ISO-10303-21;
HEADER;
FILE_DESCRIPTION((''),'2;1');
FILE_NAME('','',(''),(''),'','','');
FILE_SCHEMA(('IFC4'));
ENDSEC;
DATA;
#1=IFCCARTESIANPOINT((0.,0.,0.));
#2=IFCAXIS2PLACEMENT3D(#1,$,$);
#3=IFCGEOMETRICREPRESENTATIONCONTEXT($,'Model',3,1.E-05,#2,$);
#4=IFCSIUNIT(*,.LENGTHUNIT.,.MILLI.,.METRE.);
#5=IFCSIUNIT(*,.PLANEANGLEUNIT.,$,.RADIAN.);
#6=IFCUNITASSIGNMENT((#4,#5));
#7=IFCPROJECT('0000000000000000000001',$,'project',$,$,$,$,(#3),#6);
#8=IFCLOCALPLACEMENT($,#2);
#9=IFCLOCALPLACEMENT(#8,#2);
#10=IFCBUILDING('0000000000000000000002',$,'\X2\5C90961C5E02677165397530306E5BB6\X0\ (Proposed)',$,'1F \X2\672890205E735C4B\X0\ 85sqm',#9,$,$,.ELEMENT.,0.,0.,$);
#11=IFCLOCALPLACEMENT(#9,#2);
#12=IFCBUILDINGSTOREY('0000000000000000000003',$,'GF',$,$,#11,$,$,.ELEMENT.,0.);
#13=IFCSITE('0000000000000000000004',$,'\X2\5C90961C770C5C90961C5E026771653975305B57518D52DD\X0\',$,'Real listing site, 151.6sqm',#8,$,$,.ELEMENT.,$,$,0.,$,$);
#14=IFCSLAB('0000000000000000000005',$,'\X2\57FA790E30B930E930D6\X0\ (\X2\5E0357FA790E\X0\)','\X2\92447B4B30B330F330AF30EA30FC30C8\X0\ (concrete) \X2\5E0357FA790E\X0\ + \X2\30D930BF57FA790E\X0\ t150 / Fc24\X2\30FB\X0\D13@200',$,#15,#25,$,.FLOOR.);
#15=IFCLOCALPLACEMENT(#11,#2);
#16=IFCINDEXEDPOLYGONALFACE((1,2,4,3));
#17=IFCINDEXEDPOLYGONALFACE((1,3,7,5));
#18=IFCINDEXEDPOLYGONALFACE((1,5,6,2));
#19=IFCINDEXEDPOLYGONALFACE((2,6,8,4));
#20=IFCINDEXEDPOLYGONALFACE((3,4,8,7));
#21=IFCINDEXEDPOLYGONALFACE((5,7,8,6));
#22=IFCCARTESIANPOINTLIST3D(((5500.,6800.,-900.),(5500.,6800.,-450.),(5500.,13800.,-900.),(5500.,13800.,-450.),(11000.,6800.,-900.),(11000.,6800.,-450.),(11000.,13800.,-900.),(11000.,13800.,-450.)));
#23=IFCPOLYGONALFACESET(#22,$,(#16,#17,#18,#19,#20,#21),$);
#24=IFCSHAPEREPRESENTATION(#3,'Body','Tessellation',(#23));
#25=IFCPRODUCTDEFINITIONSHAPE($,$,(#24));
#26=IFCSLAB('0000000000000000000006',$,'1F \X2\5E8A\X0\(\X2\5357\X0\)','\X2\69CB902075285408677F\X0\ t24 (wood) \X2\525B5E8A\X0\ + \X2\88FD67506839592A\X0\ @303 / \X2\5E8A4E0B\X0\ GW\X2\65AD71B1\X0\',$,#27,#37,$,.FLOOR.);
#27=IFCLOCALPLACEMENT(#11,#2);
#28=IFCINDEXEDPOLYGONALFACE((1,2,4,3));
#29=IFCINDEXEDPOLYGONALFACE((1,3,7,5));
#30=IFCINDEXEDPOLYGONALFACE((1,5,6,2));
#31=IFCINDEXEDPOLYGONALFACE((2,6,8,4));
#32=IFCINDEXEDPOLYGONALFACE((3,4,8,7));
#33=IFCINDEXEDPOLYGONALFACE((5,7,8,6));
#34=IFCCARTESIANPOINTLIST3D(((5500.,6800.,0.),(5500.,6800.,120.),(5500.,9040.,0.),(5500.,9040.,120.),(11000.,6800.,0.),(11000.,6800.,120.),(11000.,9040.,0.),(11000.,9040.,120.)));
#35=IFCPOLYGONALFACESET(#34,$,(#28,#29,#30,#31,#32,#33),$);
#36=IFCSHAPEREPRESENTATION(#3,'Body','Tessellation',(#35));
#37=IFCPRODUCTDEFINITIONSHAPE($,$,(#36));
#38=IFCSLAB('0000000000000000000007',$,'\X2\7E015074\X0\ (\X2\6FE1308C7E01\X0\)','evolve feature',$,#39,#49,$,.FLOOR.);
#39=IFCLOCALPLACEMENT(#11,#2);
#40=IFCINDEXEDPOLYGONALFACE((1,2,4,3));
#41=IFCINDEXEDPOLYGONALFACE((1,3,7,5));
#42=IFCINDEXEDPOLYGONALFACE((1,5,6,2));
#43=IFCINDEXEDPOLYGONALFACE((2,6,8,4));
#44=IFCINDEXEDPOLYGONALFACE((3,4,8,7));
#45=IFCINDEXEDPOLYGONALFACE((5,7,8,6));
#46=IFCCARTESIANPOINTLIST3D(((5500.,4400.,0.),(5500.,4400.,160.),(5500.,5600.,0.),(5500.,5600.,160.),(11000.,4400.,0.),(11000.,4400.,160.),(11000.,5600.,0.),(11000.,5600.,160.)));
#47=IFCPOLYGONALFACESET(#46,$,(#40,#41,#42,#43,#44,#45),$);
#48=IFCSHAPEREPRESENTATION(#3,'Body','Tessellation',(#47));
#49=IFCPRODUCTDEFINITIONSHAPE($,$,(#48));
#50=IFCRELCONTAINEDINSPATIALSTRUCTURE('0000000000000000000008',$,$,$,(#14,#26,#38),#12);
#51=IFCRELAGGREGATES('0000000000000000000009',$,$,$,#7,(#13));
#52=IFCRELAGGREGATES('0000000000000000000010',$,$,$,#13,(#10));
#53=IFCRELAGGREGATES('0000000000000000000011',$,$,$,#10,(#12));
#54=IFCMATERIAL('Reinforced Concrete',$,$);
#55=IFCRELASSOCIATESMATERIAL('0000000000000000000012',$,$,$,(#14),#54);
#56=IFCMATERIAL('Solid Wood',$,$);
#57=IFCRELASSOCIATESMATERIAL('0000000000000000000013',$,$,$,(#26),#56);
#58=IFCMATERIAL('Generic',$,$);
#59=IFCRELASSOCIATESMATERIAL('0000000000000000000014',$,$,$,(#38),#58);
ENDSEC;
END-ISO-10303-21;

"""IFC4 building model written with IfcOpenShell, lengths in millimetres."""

from ifc_helpers import new_model, si_unit, frame, frame_2d, origin, place, context, project, spatial, rectangle, extrude, material, element, save


model = new_model("IFC4")

# Units and contexts
model_context = context("Model", 3, precision=1e-05, world=origin())
ifc_project = project(units=[si_unit("LENGTHUNIT", "METRE", prefix="MILLI"), si_unit("PLANEANGLEUNIT", "RADIAN")], contexts=[model_context])

# Site, building, storey
site_placement = place(None, origin())
site = spatial("IfcSite", under=ifc_project, at=site_placement, Name="岐阜県岐阜市東改田字再勝", ObjectType="Real listing site, 151.6sqm", CompositionType="ELEMENT", RefElevation=0.0)
building_placement = place(site_placement, origin())
building = spatial("IfcBuilding", under=site, at=building_placement, Name="岐阜市東改田の家 (Proposed)", ObjectType="1F 木造平屋 85sqm", CompositionType="ELEMENT", ElevationOfRefHeight=0.0, ElevationOfTerrain=0.0)
storey_placement = place(building_placement, origin())
storey = spatial("IfcBuildingStorey", under=building, at=storey_placement, Name="GF", CompositionType="ELEMENT", Elevation=0.0)

# Slabs
ifc_material_1 = material(Name="Reinforced Concrete")
slab_1_placement = place(storey_placement, frame((2750.0, 3400.0, -450.0)))
element("IfcSlab", 1, at=slab_1_placement, inside=storey, material=ifc_material_1, Name="基礎スラブ (布基礎)", Description="鉄筋コンクリート (concrete) 布基礎 + ベタ基礎 t150 / Fc24・D13@200", PredefinedType="FLOOR", context=model_context, shape_type="SweptSolid", body=[
    extrude(rectangle(XDim=5500.0, YDim=7000.0, at=frame_2d((2750.0, 3500.0))), frame((2750.0, 3400.0, -450.0)), (0.0, 0.0, 1.0), 450.0),
])
ifc_material_2 = material(Name="Solid Wood")
slab_2_placement = place(storey_placement, frame((2750.0, 3400.0, 0.0)))
element("IfcSlab", 2, at=slab_2_placement, inside=storey, material=ifc_material_2, Name="1F 床(南)", Description="構造用合板 t24 (wood) 剛床 + 製材根太 @303 / 床下 GW断熱", PredefinedType="FLOOR", context=model_context, shape_type="SweptSolid", body=[
    extrude(rectangle(XDim=5500.0, YDim=2240.0, at=frame_2d((2750.0, 1120.0))), frame((2750.0, 3400.0, 0.0)), (0.0, 0.0, 1.0), 120.0),
])
ifc_material_3 = material(Name="Generic")
slab_3_placement = place(storey_placement, frame((2750.0, 2200.0, 0.0)))
element("IfcSlab", 3, at=slab_3_placement, inside=storey, material=ifc_material_3, Name="縁側 (濡れ縁)", Description="evolve feature", PredefinedType="FLOOR", context=model_context, shape_type="SweptSolid", body=[
    extrude(rectangle(XDim=5500.0, YDim=1200.0, at=frame_2d((2750.0, 600.0))), frame((2750.0, 2200.0, 0.0)), (0.0, 0.0, 1.0), 160.0),
])

save(model, "model.ifc")
